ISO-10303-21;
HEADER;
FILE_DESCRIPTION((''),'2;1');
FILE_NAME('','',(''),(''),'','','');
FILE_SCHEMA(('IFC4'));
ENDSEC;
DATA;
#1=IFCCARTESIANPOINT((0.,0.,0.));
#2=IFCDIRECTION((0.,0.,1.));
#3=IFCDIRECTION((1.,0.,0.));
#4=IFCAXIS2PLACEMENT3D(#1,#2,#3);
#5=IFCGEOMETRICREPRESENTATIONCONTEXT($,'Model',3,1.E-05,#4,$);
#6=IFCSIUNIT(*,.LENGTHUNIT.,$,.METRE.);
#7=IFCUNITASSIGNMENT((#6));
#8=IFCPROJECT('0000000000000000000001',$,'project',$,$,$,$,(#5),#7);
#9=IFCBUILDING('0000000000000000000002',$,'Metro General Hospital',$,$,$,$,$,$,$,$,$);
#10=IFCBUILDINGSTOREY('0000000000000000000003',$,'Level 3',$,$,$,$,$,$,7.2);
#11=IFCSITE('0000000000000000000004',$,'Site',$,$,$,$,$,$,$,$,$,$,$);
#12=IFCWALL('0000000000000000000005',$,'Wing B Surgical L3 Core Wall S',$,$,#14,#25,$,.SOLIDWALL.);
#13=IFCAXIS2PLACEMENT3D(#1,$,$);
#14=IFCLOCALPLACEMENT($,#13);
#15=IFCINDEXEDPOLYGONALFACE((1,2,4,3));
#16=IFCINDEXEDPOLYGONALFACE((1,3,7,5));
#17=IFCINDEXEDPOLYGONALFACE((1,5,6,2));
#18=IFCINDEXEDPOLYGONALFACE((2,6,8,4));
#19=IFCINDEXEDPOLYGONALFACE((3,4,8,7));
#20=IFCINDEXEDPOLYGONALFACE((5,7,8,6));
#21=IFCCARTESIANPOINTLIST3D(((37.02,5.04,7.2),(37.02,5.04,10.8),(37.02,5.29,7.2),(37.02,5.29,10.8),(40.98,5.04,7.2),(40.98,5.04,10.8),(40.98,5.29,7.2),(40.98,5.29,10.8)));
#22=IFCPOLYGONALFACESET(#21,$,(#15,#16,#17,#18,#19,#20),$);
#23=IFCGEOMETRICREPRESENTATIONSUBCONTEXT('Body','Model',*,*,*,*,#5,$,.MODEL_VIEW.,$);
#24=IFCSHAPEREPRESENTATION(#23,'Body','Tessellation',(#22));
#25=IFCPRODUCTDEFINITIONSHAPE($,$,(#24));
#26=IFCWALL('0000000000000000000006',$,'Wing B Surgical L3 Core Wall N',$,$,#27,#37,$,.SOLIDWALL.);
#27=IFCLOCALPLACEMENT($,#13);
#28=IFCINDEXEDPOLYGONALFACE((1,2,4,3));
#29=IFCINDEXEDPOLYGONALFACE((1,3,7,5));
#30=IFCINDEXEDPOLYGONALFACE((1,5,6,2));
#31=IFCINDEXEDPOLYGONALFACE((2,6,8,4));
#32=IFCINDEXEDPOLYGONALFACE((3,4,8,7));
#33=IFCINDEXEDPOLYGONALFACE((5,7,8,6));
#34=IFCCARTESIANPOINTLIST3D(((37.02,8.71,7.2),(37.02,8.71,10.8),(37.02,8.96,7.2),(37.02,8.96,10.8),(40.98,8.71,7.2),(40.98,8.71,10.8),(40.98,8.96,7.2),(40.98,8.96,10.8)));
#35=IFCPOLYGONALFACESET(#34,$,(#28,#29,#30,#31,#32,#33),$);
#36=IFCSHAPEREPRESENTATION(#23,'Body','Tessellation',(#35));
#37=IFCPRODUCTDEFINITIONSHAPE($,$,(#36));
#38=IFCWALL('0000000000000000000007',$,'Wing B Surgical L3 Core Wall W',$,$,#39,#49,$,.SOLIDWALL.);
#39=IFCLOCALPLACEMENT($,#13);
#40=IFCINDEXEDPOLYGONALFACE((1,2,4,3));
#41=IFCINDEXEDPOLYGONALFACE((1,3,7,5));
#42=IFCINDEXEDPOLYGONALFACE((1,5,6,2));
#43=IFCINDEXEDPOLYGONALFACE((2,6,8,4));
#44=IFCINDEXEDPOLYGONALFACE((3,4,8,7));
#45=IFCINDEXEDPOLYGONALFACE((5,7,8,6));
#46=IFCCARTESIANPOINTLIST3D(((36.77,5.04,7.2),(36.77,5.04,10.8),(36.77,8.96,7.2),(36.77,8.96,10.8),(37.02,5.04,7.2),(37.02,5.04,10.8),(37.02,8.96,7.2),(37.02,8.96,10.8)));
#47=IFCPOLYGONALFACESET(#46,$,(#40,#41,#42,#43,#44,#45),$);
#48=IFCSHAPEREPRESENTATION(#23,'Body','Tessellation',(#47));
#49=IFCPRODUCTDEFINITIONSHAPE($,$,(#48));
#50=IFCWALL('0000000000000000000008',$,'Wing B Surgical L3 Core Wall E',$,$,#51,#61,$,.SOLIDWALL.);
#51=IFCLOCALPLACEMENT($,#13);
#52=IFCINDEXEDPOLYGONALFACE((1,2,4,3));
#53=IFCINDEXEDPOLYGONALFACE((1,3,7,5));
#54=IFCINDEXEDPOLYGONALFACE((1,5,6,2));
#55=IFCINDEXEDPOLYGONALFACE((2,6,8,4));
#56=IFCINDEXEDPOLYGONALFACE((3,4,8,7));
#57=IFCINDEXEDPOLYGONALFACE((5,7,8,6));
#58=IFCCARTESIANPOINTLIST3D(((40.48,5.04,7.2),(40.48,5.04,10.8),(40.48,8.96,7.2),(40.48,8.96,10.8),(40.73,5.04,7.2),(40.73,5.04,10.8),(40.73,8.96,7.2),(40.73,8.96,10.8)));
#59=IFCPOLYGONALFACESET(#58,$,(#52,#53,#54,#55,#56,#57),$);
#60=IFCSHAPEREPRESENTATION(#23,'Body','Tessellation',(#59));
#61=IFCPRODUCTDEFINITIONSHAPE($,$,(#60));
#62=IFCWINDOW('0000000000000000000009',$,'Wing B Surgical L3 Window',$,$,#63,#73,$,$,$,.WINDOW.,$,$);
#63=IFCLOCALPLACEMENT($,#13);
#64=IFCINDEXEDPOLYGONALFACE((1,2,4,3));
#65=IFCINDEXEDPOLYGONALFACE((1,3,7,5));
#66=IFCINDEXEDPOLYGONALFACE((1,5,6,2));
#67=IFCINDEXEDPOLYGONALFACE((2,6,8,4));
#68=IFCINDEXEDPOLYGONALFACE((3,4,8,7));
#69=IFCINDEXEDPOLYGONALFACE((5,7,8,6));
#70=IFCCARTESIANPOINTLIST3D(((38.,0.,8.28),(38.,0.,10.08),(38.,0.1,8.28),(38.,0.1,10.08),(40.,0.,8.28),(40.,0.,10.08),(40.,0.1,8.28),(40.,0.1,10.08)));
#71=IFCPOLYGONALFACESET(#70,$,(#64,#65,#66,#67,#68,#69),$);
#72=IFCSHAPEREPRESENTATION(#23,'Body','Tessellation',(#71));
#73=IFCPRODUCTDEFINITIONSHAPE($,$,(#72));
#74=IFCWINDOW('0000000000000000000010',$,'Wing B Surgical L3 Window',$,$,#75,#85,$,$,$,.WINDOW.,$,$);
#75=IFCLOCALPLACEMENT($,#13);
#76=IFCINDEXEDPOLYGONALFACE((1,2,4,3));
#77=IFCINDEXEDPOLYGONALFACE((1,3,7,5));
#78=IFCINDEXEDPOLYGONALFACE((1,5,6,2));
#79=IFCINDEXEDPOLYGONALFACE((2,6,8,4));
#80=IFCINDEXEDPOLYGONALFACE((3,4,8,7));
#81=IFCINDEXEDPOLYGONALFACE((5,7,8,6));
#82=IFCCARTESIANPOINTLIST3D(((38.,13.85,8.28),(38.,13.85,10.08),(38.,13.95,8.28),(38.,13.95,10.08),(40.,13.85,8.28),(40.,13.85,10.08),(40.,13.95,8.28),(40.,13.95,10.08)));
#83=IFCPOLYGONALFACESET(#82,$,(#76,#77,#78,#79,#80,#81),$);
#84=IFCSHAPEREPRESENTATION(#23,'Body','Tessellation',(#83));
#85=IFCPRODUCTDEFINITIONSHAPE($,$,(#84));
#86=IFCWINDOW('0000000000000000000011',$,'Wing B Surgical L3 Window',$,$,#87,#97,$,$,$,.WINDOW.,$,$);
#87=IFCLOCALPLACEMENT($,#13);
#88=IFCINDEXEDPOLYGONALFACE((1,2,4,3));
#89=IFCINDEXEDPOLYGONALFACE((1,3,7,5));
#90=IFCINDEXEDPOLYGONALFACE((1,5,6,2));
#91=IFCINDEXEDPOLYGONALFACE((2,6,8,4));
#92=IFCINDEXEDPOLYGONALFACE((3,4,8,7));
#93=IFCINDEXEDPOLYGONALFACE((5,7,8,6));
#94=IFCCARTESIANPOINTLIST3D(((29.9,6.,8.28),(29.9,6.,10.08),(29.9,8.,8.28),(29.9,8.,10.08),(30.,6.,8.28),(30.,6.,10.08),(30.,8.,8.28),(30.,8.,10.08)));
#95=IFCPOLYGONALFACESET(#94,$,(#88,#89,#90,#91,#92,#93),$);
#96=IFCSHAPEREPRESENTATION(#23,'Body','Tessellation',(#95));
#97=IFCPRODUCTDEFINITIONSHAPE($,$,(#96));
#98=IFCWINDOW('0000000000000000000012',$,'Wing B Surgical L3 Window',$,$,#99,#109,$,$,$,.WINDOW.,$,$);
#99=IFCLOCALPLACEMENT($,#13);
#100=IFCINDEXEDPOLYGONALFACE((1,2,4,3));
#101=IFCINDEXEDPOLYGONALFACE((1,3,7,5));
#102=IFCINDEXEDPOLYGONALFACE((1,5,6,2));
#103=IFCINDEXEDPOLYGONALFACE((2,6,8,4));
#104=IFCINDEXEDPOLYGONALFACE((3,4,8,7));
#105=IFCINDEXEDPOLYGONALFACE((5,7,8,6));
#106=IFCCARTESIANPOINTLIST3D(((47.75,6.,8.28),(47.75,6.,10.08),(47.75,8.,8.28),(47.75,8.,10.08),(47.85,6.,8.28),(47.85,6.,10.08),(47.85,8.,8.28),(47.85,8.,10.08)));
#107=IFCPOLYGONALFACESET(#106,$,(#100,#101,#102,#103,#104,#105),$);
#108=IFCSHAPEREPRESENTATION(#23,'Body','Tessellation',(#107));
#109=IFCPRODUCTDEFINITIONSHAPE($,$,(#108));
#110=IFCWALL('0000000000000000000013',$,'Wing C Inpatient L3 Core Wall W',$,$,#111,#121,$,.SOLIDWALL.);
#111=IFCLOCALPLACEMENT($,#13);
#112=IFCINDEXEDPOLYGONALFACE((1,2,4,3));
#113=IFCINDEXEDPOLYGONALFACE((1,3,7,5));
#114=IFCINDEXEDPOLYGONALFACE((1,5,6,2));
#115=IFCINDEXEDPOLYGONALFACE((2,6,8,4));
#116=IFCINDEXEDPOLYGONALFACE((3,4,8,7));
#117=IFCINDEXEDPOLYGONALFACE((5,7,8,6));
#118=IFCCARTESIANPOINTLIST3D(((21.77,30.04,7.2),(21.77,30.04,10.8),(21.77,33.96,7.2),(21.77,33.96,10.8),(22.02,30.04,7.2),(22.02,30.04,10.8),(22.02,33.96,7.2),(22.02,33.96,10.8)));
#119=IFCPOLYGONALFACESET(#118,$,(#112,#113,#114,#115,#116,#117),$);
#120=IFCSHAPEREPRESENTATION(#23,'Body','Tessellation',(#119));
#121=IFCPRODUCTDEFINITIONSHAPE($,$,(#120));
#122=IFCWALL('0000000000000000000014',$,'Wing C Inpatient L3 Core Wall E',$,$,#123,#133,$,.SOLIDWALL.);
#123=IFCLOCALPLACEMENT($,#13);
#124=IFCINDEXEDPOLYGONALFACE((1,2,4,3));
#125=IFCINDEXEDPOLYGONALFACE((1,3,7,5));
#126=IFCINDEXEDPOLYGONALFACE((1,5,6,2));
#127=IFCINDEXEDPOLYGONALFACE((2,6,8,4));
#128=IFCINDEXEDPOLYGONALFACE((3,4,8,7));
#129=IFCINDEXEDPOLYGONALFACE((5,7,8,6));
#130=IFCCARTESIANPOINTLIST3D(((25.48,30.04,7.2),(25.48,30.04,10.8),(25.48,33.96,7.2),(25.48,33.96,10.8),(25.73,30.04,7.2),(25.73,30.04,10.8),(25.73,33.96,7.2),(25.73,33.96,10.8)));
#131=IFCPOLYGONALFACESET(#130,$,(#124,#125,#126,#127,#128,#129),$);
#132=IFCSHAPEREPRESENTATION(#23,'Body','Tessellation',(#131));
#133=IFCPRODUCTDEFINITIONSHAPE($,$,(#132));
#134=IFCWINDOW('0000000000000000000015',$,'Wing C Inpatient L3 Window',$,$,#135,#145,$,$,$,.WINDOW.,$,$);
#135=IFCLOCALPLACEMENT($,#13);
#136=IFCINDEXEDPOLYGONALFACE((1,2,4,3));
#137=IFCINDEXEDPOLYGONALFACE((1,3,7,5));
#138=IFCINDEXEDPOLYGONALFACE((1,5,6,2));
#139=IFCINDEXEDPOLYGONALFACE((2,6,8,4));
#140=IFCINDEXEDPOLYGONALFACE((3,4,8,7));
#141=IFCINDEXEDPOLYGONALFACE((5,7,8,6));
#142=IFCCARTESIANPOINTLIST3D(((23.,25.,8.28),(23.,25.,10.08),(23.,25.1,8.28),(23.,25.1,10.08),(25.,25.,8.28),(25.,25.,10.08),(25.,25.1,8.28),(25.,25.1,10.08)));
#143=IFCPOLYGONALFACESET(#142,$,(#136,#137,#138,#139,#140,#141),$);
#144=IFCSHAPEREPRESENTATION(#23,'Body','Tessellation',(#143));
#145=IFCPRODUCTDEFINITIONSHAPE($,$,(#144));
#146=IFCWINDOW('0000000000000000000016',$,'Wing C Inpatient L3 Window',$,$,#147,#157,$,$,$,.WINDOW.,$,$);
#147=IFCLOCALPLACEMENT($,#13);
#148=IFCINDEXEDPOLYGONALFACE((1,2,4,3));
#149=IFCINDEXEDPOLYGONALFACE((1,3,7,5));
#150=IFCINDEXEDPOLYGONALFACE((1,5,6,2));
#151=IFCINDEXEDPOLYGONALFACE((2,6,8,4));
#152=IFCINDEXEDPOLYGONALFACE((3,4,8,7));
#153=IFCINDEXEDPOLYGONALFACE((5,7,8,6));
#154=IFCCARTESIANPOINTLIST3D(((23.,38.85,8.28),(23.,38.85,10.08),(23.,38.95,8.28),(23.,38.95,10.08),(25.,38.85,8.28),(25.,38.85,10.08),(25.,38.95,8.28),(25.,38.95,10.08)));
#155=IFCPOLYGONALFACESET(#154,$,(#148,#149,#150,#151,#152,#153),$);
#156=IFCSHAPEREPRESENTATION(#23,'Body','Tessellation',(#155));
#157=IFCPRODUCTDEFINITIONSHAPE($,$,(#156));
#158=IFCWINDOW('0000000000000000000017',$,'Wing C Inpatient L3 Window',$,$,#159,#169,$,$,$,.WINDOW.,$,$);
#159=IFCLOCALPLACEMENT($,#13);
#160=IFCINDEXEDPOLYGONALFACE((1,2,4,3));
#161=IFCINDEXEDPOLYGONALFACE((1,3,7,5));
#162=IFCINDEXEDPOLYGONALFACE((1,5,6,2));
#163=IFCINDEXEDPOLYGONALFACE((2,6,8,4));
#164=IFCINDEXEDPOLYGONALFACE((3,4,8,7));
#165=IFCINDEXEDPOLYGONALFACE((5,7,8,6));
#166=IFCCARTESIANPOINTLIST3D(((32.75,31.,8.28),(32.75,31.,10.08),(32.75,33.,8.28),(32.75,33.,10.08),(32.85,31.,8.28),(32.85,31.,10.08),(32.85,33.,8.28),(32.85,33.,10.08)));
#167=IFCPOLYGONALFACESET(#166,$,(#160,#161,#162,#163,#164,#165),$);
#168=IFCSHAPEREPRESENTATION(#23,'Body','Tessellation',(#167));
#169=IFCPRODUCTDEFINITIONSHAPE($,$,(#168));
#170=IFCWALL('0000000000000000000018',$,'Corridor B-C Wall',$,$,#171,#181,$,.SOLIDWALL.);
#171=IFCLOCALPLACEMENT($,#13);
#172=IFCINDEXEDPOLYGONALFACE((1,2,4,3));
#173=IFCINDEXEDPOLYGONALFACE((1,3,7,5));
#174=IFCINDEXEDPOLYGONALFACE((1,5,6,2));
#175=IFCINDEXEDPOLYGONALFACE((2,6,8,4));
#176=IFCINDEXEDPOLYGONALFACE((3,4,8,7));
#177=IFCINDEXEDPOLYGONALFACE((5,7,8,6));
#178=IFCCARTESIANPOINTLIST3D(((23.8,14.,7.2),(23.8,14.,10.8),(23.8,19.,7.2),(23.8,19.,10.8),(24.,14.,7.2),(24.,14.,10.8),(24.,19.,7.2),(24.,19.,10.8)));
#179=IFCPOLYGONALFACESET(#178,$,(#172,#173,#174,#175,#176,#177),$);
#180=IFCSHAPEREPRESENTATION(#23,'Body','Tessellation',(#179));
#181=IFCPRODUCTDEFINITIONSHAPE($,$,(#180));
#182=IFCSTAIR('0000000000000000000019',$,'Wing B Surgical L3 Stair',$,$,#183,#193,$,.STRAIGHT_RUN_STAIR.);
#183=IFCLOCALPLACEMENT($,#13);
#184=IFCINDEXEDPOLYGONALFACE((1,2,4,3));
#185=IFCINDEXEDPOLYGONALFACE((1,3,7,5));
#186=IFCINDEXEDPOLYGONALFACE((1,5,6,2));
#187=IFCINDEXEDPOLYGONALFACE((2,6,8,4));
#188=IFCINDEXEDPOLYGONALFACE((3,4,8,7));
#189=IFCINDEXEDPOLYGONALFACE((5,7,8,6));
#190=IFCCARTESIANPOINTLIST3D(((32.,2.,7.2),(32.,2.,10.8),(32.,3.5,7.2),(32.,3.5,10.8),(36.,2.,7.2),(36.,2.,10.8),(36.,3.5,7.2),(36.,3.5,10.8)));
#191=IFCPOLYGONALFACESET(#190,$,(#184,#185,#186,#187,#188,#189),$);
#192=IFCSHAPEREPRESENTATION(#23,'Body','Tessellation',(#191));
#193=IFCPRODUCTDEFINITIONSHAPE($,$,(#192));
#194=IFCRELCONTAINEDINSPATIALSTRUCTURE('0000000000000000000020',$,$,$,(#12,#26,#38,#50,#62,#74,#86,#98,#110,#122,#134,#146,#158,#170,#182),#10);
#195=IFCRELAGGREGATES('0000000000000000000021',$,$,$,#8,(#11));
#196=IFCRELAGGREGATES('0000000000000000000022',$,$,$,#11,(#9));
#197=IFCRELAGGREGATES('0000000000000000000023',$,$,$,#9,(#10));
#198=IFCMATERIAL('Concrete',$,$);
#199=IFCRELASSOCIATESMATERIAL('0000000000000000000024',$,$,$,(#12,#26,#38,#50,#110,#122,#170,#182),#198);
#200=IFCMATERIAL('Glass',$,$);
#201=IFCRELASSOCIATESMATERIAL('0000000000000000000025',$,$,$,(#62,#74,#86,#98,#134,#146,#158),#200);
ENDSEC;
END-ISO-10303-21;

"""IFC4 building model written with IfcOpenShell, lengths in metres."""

from ifc_helpers import new_model, si_unit, frame, origin_with_axes, place, context, subcontext, project, spatial, line, indexed_curve, outline, extrude, material, element, save


model = new_model("IFC4")

# Units and contexts
model_context = context("Model", 3, precision=1e-05, world=origin_with_axes())
body_context = subcontext(model_context, "Body", "Model", "MODEL_VIEW")
ifc_project = project(units=[si_unit("LENGTHUNIT", "METRE")], contexts=[model_context])

# Site, building, storey
site = spatial("IfcSite", under=ifc_project, Name="Site")
building = spatial("IfcBuilding", under=site, Name="Metro General Hospital")
storey = spatial("IfcBuildingStorey", under=building, Name="Level 3", Elevation=7.2)

# Shared definitions
ifc_material_1 = material(Name="Concrete")

# Walls
for number, where, z_axis, x_axis, name in (
    (1, (37.02, 5.04, 7.2), (0.0, 0.0, 1.0), (1.0, 0.0, 0.0), "Wing B Surgical L3 Core Wall S"),
    (2, (37.02, 8.71, 7.2), (0.0, 0.0, 1.0), (1.0, 0.0, 0.0), "Wing B Surgical L3 Core Wall N"),
):
    element("IfcWall", number, at=place(None, frame(where, z_axis=z_axis, x_axis=x_axis)), inside=storey, material=ifc_material_1, Name=name, PredefinedType="SOLIDWALL", context=body_context, shape_type="SweptSolid", body=[
        extrude(outline(indexed_curve([(0.0, 0.0), (3.96, 0.0), (3.96, 0.25), (0.0, 0.25)], segments=[line(1, 2, 3, 4, 1)])), origin_with_axes(), (0.0, 0.0, 1.0), 3.6),
    ])
for number, where, z_axis, x_axis, name in (
    (3, (37.02, 5.04, 7.2), (0.0, 0.0, 1.0), (0.0, 1.0, 0.0), "Wing B Surgical L3 Core Wall W"),
    (4, (40.73, 5.04, 7.2), (0.0, 0.0, 1.0), (0.0, 1.0, 0.0), "Wing B Surgical L3 Core Wall E"),
):
    element("IfcWall", number, at=place(None, frame(where, z_axis=z_axis, x_axis=x_axis)), inside=storey, material=ifc_material_1, Name=name, PredefinedType="SOLIDWALL", context=body_context, shape_type="SweptSolid", body=[
        extrude(outline(indexed_curve([(0.0, 0.0), (3.92, 0.0), (3.92, 0.25), (0.0, 0.25)], segments=[line(1, 2, 3, 4, 1)])), origin_with_axes(), (0.0, 0.0, 1.0), 3.6),
    ])

# Windows
ifc_material_2 = material(Name="Glass")
for number, where, z_axis, x_axis, name in (
    (5, (38.0, 0.0, 8.28), (0.0, 0.0, 1.0), (1.0, 0.0, 0.0), "Wing B Surgical L3 Window"),
    (6, (38.0, 13.85, 8.28), (0.0, 0.0, 1.0), (1.0, 0.0, 0.0), "Wing B Surgical L3 Window"),
    (7, (30.0, 6.0, 8.28), (0.0, 0.0, 1.0), (0.0, 1.0, 0.0), "Wing B Surgical L3 Window"),
    (8, (47.85, 6.0, 8.28), (0.0, 0.0, 1.0), (0.0, 1.0, 0.0), "Wing B Surgical L3 Window"),
):
    element("IfcWindow", number, at=place(None, frame(where, z_axis=z_axis, x_axis=x_axis)), inside=storey, material=ifc_material_2, Name=name, PredefinedType="WINDOW", context=body_context, shape_type="SweptSolid", body=[
        extrude(outline(indexed_curve([(0.0, 0.0), (2.0, 0.0), (2.0, 0.1), (0.0, 0.1)], segments=[line(1, 2, 3, 4, 1)])), origin_with_axes(), (0.0, 0.0, 1.0), 1.8),
    ])

# Walls
for number, where, z_axis, x_axis, name in (
    (9, (22.02, 30.04, 7.2), (0.0, 0.0, 1.0), (0.0, 1.0, 0.0), "Wing C Inpatient L3 Core Wall W"),
    (10, (25.73, 30.04, 7.2), (0.0, 0.0, 1.0), (0.0, 1.0, 0.0), "Wing C Inpatient L3 Core Wall E"),
):
    element("IfcWall", number, at=place(None, frame(where, z_axis=z_axis, x_axis=x_axis)), inside=storey, material=ifc_material_1, Name=name, PredefinedType="SOLIDWALL", context=body_context, shape_type="SweptSolid", body=[
        extrude(outline(indexed_curve([(0.0, 0.0), (3.92, 0.0), (3.92, 0.25), (0.0, 0.25)], segments=[line(1, 2, 3, 4, 1)])), origin_with_axes(), (0.0, 0.0, 1.0), 3.6),
    ])

# Windows
for number, where, z_axis, x_axis, name in (
    (11, (23.0, 25.0, 8.28), (0.0, 0.0, 1.0), (1.0, 0.0, 0.0), "Wing C Inpatient L3 Window"),
    (12, (23.0, 38.85, 8.28), (0.0, 0.0, 1.0), (1.0, 0.0, 0.0), "Wing C Inpatient L3 Window"),
    (13, (32.85, 31.0, 8.28), (0.0, 0.0, 1.0), (0.0, 1.0, 0.0), "Wing C Inpatient L3 Window"),
):
    element("IfcWindow", number, at=place(None, frame(where, z_axis=z_axis, x_axis=x_axis)), inside=storey, material=ifc_material_2, Name=name, PredefinedType="WINDOW", context=body_context, shape_type="SweptSolid", body=[
        extrude(outline(indexed_curve([(0.0, 0.0), (2.0, 0.0), (2.0, 0.1), (0.0, 0.1)], segments=[line(1, 2, 3, 4, 1)])), origin_with_axes(), (0.0, 0.0, 1.0), 1.8),
    ])

# Wall
wall_placement = place(None, frame((24.0, 14.0, 7.2), z_axis=(0.0, 0.0, 1.0), x_axis=(0.0, 1.0, 0.0)))
element("IfcWall", 14, at=wall_placement, inside=storey, material=ifc_material_1, Name="Corridor B-C Wall", PredefinedType="SOLIDWALL", context=body_context, shape_type="SweptSolid", body=[
    extrude(outline(indexed_curve([(0.0, 0.0), (5.0, 0.0), (5.0, 0.2), (0.0, 0.2)], segments=[line(1, 2, 3, 4, 1)])), origin_with_axes(), (0.0, 0.0, 1.0), 3.6),
])

# Stair
stair_placement = place(None, frame((32.0, 2.0, 7.2), z_axis=(0.0, 0.0, 1.0), x_axis=(1.0, 0.0, 0.0)))
element("IfcStair", 15, at=stair_placement, inside=storey, material=ifc_material_1, Name="Wing B Surgical L3 Stair", PredefinedType="STRAIGHT_RUN_STAIR", context=body_context, shape_type="SweptSolid", body=[
    extrude(outline(indexed_curve([(0.0, 0.0), (4.0, 0.0), (4.0, 1.5), (0.0, 1.5)], segments=[line(1, 2, 3, 4, 1)])), origin_with_axes(), (0.0, 0.0, 1.0), 3.6),
])

save(model, "model.ifc")
